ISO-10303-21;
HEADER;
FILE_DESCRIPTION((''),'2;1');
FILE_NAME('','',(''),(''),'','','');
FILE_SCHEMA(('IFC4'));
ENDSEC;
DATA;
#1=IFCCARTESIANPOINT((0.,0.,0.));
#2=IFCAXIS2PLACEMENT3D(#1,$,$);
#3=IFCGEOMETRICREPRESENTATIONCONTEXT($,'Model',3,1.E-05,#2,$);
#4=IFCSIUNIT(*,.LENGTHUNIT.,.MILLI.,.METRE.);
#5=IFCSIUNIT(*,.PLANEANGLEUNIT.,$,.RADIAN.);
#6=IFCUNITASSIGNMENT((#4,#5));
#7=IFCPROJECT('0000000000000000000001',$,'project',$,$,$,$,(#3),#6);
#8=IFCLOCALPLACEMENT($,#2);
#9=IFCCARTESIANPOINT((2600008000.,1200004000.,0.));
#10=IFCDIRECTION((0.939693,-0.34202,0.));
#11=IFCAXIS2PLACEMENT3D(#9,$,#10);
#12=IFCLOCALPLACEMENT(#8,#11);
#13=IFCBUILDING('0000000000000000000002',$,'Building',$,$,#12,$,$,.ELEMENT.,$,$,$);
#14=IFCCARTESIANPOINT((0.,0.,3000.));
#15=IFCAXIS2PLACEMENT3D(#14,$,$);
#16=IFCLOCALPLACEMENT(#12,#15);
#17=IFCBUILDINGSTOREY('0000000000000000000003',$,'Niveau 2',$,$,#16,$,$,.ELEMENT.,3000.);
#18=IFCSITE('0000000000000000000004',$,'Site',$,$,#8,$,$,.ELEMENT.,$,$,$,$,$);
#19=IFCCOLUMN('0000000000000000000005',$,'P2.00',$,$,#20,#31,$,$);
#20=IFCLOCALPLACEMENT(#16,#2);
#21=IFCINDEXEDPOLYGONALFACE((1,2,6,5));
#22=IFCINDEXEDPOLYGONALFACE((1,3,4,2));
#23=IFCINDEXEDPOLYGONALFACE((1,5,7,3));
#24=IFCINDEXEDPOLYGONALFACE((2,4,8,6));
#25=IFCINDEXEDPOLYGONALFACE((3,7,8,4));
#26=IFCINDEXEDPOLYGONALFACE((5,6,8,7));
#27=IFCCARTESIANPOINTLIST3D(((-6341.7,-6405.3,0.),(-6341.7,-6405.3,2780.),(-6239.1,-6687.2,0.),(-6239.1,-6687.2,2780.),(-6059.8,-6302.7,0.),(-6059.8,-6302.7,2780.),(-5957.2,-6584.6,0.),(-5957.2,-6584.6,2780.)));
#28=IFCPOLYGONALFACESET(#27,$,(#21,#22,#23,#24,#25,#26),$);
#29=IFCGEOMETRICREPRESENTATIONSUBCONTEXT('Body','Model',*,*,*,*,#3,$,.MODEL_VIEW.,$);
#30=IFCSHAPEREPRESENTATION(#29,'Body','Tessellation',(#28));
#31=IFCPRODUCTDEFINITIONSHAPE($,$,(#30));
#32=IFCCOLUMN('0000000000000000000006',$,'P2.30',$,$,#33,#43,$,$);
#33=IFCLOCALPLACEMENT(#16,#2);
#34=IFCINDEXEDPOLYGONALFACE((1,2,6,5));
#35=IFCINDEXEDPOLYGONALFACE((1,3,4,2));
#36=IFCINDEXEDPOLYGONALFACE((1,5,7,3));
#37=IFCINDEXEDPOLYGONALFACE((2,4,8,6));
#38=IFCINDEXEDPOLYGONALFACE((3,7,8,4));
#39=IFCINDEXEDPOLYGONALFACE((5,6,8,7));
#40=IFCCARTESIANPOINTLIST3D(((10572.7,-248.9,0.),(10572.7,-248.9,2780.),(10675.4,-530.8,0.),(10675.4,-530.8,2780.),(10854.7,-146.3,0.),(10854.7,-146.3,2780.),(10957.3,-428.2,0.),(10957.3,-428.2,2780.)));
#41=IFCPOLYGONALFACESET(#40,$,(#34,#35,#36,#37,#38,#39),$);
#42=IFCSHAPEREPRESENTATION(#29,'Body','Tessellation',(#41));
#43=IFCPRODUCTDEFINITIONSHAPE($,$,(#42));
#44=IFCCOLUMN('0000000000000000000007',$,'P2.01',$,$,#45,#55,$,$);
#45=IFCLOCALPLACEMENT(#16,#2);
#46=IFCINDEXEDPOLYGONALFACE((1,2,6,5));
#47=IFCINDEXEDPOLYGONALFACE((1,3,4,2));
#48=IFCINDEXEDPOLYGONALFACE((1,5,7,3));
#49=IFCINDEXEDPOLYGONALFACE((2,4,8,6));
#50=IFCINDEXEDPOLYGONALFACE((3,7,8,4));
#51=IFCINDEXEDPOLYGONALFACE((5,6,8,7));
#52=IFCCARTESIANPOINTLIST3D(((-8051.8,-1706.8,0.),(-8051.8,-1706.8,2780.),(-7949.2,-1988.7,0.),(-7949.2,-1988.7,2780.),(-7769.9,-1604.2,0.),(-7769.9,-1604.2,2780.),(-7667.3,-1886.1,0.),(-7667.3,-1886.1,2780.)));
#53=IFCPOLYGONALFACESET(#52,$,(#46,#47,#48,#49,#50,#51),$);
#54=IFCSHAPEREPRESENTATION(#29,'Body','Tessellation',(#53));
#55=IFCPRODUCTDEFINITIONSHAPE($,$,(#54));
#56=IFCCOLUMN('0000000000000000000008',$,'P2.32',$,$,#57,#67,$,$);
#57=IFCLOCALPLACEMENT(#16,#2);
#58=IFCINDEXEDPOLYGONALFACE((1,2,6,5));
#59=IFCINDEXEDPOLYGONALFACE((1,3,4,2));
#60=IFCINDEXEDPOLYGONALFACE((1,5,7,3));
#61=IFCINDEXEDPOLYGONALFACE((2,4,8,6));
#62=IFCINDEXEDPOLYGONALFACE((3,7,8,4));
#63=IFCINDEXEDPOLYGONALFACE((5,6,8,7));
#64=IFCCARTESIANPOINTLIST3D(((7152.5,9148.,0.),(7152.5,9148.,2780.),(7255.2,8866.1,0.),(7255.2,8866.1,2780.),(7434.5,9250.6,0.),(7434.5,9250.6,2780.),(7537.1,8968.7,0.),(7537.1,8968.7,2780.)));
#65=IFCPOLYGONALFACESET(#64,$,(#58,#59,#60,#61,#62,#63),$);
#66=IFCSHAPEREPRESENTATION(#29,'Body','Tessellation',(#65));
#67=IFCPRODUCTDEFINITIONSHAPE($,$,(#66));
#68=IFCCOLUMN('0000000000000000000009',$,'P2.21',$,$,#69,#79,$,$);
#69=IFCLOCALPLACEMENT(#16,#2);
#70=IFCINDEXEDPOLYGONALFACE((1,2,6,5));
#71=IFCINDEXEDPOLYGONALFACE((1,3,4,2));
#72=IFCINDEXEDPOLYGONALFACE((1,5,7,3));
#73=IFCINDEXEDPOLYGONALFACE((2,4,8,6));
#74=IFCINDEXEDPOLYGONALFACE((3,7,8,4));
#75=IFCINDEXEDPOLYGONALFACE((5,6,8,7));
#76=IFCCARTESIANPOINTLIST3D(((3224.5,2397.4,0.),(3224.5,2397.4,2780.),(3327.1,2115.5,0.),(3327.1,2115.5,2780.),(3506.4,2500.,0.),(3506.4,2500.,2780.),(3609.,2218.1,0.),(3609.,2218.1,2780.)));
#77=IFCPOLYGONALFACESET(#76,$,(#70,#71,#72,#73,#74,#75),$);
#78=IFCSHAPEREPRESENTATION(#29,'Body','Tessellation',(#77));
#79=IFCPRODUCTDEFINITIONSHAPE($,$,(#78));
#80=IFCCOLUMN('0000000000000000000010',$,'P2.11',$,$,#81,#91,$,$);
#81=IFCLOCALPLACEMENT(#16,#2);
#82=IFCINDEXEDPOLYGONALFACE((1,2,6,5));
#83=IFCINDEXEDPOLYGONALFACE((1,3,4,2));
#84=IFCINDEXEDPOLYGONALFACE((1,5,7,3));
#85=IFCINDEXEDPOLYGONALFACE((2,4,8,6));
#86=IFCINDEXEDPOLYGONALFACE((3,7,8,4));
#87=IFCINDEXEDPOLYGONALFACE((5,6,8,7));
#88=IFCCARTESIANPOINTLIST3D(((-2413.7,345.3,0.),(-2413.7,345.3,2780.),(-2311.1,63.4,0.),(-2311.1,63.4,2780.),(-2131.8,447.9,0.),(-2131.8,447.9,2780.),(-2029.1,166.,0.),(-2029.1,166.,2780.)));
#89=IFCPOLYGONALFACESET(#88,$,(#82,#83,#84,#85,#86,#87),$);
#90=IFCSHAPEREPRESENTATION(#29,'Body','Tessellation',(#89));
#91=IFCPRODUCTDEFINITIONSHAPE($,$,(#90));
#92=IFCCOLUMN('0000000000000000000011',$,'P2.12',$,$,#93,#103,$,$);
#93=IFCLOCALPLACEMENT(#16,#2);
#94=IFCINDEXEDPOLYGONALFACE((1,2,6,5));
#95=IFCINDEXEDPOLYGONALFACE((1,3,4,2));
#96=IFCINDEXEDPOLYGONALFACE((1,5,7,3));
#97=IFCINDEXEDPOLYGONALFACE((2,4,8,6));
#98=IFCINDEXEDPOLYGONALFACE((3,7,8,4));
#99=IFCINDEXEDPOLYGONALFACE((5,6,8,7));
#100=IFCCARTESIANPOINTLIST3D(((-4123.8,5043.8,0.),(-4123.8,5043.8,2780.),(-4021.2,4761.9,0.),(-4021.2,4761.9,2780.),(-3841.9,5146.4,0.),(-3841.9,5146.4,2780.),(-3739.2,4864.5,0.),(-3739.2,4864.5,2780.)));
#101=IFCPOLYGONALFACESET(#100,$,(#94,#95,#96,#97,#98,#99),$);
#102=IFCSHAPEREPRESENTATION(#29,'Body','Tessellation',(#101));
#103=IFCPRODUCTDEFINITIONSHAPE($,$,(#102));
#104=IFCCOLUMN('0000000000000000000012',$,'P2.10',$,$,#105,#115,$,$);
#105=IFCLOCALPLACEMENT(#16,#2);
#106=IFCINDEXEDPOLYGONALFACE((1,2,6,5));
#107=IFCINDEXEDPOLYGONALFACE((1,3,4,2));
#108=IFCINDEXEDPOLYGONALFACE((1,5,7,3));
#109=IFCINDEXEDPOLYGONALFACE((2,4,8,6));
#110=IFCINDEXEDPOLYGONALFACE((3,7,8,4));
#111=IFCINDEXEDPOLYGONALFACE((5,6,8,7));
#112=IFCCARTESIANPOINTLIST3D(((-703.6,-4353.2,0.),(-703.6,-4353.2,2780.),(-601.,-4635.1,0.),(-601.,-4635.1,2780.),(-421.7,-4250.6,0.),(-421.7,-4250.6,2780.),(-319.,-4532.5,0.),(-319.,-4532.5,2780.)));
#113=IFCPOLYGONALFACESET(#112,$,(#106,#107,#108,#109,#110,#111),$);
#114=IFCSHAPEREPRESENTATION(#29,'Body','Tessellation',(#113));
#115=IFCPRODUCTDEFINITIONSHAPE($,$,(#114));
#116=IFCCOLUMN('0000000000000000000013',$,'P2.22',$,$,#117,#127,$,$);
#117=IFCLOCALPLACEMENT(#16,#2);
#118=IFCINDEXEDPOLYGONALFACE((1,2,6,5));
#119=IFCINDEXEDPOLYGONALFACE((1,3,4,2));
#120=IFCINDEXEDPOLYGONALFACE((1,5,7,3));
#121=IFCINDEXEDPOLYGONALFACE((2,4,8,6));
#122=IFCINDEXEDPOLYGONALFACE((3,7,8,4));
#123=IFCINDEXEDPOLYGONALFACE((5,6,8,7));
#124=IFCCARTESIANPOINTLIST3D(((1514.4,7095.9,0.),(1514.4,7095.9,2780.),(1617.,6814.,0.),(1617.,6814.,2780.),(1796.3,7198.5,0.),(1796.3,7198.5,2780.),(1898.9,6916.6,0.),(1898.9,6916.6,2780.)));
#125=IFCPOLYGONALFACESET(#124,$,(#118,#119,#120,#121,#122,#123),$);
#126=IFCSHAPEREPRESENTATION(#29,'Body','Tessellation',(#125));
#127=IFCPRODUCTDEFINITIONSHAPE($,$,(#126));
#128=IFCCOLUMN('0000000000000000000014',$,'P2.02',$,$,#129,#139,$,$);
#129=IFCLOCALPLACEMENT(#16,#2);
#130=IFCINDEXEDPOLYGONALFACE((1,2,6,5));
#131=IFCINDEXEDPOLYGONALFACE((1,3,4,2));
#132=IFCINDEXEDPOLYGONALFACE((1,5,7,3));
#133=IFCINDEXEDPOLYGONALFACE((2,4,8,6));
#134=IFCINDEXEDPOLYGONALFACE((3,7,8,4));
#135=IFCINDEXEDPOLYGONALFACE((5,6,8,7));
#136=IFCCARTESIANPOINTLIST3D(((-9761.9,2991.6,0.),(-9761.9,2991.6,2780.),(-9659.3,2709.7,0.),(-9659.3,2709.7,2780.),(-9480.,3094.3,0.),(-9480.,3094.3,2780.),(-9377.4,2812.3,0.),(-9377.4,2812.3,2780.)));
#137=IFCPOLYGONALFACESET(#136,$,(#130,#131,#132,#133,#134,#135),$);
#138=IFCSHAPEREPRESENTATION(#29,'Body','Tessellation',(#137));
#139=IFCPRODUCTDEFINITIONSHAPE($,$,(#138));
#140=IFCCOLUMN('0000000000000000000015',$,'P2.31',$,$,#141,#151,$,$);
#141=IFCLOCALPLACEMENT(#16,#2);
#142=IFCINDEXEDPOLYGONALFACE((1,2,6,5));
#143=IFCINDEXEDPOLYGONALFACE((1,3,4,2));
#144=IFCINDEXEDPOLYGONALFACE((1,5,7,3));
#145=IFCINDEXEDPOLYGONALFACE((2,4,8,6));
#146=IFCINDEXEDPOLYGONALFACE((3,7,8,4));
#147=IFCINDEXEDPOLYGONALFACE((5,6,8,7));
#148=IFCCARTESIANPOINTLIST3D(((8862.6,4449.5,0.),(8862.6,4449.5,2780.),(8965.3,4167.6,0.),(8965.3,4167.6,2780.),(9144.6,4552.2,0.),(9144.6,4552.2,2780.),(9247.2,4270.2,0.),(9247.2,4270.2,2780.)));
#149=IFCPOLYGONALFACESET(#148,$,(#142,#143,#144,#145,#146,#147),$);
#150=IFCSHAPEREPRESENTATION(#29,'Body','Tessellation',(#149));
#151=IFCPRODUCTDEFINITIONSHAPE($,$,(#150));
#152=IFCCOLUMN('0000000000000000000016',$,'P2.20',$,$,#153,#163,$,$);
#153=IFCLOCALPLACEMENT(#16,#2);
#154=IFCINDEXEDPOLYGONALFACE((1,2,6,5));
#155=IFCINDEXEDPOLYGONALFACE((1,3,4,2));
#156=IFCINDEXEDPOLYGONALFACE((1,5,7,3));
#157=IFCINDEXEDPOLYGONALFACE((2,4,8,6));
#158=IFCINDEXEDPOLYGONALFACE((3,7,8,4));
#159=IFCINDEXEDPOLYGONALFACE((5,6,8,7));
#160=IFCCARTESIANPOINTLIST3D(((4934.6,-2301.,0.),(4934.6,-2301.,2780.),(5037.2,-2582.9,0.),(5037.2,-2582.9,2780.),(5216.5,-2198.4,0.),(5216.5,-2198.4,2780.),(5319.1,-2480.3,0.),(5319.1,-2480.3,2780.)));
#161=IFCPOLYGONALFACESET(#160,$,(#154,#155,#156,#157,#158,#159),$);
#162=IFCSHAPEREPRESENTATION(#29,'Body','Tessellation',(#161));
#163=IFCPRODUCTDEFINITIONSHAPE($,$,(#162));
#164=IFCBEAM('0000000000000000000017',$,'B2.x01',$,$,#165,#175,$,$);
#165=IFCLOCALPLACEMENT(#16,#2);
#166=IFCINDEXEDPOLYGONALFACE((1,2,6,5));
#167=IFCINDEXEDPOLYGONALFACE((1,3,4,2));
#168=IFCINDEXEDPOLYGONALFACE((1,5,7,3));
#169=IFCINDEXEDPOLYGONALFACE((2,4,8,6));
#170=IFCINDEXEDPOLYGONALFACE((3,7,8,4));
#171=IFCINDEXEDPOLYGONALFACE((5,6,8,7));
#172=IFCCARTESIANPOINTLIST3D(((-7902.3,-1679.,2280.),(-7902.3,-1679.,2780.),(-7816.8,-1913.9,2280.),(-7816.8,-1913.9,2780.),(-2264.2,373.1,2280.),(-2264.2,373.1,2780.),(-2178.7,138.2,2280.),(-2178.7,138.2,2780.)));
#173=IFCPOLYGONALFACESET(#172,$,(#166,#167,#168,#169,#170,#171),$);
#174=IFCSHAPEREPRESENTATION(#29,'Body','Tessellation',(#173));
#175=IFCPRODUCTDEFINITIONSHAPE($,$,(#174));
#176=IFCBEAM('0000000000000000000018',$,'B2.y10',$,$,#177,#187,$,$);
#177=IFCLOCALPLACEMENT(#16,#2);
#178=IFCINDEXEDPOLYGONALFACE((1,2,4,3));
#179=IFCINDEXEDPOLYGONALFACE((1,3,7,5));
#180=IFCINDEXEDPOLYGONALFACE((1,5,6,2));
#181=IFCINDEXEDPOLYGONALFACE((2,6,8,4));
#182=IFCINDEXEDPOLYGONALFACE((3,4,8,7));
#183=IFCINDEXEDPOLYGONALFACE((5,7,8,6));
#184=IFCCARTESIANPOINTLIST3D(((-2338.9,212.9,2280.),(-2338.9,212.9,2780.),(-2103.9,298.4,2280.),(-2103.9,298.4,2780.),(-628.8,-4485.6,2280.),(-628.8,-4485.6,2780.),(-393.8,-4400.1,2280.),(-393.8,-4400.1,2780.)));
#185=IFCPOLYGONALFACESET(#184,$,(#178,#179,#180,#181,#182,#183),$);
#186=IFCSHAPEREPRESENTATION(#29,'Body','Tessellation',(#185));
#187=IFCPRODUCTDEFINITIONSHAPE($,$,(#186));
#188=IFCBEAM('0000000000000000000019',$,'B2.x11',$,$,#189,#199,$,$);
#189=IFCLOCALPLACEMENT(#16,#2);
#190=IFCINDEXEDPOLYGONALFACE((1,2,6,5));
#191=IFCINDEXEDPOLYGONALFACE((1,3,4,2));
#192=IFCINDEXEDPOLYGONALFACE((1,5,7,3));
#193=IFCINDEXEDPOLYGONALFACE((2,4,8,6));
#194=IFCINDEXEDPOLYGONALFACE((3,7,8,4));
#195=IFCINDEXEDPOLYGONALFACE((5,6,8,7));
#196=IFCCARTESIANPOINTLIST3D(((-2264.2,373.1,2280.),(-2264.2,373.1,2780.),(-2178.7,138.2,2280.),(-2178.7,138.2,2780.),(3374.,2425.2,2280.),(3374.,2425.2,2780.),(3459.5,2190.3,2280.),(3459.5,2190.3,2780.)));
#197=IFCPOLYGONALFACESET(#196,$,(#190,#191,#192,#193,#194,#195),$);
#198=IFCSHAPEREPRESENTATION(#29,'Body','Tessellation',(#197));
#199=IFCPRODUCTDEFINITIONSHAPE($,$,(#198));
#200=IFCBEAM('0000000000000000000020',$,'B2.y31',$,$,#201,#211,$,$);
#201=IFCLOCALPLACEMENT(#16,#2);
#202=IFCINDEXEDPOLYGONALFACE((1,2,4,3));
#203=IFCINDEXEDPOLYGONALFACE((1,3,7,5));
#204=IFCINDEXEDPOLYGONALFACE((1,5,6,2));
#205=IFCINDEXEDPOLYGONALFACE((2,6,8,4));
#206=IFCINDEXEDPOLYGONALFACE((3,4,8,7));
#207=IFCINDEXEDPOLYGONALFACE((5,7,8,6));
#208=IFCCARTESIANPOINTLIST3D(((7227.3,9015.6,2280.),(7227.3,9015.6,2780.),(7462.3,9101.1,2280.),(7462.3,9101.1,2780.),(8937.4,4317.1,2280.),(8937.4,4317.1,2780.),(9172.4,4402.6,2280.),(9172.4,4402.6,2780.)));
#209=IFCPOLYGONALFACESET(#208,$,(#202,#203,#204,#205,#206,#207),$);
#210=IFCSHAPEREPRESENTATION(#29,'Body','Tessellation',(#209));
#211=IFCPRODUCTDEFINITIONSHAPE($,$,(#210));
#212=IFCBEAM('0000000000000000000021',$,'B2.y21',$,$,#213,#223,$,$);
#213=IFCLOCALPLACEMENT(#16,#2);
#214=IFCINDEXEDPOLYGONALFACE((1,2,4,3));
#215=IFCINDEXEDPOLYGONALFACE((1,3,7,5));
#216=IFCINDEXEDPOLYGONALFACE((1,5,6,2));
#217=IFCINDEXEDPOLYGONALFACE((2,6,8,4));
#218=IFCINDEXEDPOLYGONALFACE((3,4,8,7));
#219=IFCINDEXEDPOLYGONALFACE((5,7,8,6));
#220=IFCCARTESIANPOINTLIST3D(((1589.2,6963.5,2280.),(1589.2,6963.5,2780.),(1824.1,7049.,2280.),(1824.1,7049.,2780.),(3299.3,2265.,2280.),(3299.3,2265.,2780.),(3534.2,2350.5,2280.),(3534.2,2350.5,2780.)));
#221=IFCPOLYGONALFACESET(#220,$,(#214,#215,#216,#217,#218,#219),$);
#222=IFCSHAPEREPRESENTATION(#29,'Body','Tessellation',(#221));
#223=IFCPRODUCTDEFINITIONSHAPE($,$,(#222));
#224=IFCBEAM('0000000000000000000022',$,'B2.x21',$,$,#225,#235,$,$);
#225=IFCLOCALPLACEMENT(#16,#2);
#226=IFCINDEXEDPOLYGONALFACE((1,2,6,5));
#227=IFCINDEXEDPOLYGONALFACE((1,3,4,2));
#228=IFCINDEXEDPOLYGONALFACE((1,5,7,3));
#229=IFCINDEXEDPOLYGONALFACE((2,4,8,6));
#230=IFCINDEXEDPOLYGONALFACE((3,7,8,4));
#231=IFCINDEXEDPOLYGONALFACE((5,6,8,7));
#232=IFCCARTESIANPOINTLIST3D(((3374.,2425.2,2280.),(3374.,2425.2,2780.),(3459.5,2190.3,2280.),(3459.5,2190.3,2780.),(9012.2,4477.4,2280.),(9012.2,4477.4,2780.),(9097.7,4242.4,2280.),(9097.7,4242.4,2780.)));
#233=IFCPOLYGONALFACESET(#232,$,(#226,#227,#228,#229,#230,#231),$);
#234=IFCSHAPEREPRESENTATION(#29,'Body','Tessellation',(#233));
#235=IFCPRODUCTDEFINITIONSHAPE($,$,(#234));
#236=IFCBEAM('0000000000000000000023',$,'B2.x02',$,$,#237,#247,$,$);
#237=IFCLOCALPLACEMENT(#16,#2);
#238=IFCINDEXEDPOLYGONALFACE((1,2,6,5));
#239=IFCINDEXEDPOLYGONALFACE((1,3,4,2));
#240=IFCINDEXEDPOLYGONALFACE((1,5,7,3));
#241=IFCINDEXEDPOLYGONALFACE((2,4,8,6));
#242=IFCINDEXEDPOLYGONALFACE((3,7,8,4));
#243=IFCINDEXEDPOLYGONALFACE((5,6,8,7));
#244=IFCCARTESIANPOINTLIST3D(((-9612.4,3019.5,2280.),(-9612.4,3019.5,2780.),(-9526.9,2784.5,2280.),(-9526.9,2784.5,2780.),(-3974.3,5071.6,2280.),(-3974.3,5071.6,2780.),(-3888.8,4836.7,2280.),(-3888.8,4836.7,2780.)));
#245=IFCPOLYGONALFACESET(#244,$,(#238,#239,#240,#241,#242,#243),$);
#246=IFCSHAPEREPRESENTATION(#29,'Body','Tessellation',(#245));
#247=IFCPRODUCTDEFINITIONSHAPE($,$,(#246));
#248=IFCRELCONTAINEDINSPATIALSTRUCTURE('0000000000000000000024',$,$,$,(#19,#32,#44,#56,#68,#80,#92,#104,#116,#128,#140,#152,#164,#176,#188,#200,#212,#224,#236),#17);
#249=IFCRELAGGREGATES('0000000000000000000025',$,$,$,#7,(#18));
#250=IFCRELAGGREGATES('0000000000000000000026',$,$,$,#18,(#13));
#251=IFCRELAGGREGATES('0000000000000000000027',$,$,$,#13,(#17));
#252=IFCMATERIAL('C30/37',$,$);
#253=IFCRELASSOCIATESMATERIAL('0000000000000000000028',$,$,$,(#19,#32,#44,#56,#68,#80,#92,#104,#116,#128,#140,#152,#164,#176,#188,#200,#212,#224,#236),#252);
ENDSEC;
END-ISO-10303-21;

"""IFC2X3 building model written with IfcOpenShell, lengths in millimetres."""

from ifc_helpers import new_model, si_unit, frame, origin, origin_2d, place, context, subcontext, project, spatial, rectangle, extrude, material, element, save


model = new_model("IFC2X3")

# Units and contexts
model_context = context("Model", 3, precision=1e-05, world=origin())
body_context = subcontext(model_context, "Body", "Model", "MODEL_VIEW")
ifc_project = project(units=[si_unit("LENGTHUNIT", "METRE", prefix="MILLI"), si_unit("PLANEANGLEUNIT", "RADIAN")], contexts=[model_context])

# Site, building, storey
site_placement = place(None, origin())
site = spatial("IfcSite", under=ifc_project, at=site_placement, Name="Site", CompositionType="ELEMENT")
building_placement = place(site_placement, frame((2600008000.0, 1200004000.0, 0.0), x_axis=(0.939693, -0.34202, 0.0)))
building = spatial("IfcBuilding", under=site, at=building_placement, Name="Building", CompositionType="ELEMENT")
storey_placement = place(building_placement, frame((0.0, 0.0, 3000.0)))
storey = spatial("IfcBuildingStorey", under=building, at=storey_placement, Name="Niveau 2", CompositionType="ELEMENT", Elevation=3000.0)

# Columns
ifc_material = material(Name="C30/37")
for number, where, z_axis, x_axis, name in (
    (1, (-6149.5, -6494.9, 0.0), (0.0, 0.0, 1.0), (0.939693, 0.34202, 0.0), "P2.00"),
    (2, (10765.0, -338.6, 0.0), (0.0, 0.0, 1.0), (0.939693, 0.34202, 0.0), "P2.30"),
    (3, (-7859.6, -1796.5, 0.0), (0.0, 0.0, 1.0), (0.939693, 0.34202, 0.0), "P2.01"),
    (4, (7344.8, 9058.4, 0.0), (0.0, 0.0, 1.0), (0.939693, 0.34202, 0.0), "P2.32"),
    (5, (3416.8, 2307.8, 0.0), (0.0, 0.0, 1.0), (0.939693, 0.34202, 0.0), "P2.21"),
    (6, (-2221.4, 255.7, 0.0), (0.0, 0.0, 1.0), (0.939693, 0.34202, 0.0), "P2.11"),
    (7, (-3931.5, 4954.1, 0.0), (0.0, 0.0, 1.0), (0.939693, 0.34202, 0.0), "P2.12"),
    (8, (-511.3, -4442.8, 0.0), (0.0, 0.0, 1.0), (0.939693, 0.34202, 0.0), "P2.10"),
    (9, (1706.6, 7006.2, 0.0), (0.0, 0.0, 1.0), (0.939693, 0.34202, 0.0), "P2.22"),
    (10, (-9569.7, 2902.0, 0.0), (0.0, 0.0, 1.0), (0.939693, 0.34202, 0.0), "P2.02"),
    (11, (9054.9, 4359.9, 0.0), (0.0, 0.0, 1.0), (0.939693, 0.34202, 0.0), "P2.31"),
    (12, (5126.9, -2390.7, 0.0), (0.0, 0.0, 1.0), (0.939693, 0.34202, 0.0), "P2.20"),
):
    element("IfcColumn", number, at=place(storey_placement, frame(where, z_axis=z_axis, x_axis=x_axis)), inside=storey, material=ifc_material, Name=name, context=body_context, shape_type="SweptSolid", body=[
        extrude(rectangle(XDim=300.0, YDim=300.0, at=origin_2d()), origin(), (0.0, 0.0, 1.0), 2780.0),
    ])

# Beams
beam_1_placement = place(storey_placement, frame((-7859.6, -1796.5, 2530.0), z_axis=(0.939693, 0.34202, 0.0), x_axis=(-0.34202, 0.939693, 0.0)))
element("IfcBeam", 13, at=beam_1_placement, inside=storey, material=ifc_material, Name="B2.x01", context=body_context, shape_type="SweptSolid", body=[
    extrude(rectangle(XDim=250.0, YDim=500.0, at=origin_2d()), origin(), (0.0, 0.0, 1.0), 6000.0),
])
beam_2_placement = place(storey_placement, frame((-511.3, -4442.8, 2530.0), z_axis=(-0.34202, 0.939693, 0.0), x_axis=(-0.939693, -0.34202, 0.0)))
element("IfcBeam", 14, at=beam_2_placement, inside=storey, material=ifc_material, Name="B2.y10", context=body_context, shape_type="SweptSolid", body=[
    extrude(rectangle(XDim=250.0, YDim=500.0, at=origin_2d()), origin(), (0.0, 0.0, 1.0), 5000.0),
])
beam_3_placement = place(storey_placement, frame((-2221.4, 255.7, 2530.0), z_axis=(0.939693, 0.34202, 0.0), x_axis=(-0.34202, 0.939693, 0.0)))
element("IfcBeam", 15, at=beam_3_placement, inside=storey, material=ifc_material, Name="B2.x11", context=body_context, shape_type="SweptSolid", body=[
    extrude(rectangle(XDim=250.0, YDim=500.0, at=origin_2d()), origin(), (0.0, 0.0, 1.0), 6000.0),
])
for number, where, z_axis, x_axis, name in (
    (16, (9054.9, 4359.9, 2530.0), (-0.34202, 0.939693, 0.0), (-0.939693, -0.34202, 0.0), "B2.y31"),
    (17, (3416.8, 2307.8, 2530.0), (-0.34202, 0.939693, 0.0), (-0.939693, -0.34202, 0.0), "B2.y21"),
):
    element("IfcBeam", number, at=place(storey_placement, frame(where, z_axis=z_axis, x_axis=x_axis)), inside=storey, material=ifc_material, Name=name, context=body_context, shape_type="SweptSolid", body=[
        extrude(rectangle(XDim=250.0, YDim=500.0, at=origin_2d()), origin(), (0.0, 0.0, 1.0), 5000.0),
    ])
for number, where, z_axis, x_axis, name in (
    (18, (3416.8, 2307.8, 2530.0), (0.939693, 0.34202, 0.0), (-0.34202, 0.939693, 0.0), "B2.x21"),
    (19, (-9569.7, 2902.0, 2530.0), (0.939693, 0.34202, 0.0), (-0.34202, 0.939693, 0.0), "B2.x02"),
):
    element("IfcBeam", number, at=place(storey_placement, frame(where, z_axis=z_axis, x_axis=x_axis)), inside=storey, material=ifc_material, Name=name, context=body_context, shape_type="SweptSolid", body=[
        extrude(rectangle(XDim=250.0, YDim=500.0, at=origin_2d()), origin(), (0.0, 0.0, 1.0), 6000.0),
    ])

save(model, "model.ifc")
